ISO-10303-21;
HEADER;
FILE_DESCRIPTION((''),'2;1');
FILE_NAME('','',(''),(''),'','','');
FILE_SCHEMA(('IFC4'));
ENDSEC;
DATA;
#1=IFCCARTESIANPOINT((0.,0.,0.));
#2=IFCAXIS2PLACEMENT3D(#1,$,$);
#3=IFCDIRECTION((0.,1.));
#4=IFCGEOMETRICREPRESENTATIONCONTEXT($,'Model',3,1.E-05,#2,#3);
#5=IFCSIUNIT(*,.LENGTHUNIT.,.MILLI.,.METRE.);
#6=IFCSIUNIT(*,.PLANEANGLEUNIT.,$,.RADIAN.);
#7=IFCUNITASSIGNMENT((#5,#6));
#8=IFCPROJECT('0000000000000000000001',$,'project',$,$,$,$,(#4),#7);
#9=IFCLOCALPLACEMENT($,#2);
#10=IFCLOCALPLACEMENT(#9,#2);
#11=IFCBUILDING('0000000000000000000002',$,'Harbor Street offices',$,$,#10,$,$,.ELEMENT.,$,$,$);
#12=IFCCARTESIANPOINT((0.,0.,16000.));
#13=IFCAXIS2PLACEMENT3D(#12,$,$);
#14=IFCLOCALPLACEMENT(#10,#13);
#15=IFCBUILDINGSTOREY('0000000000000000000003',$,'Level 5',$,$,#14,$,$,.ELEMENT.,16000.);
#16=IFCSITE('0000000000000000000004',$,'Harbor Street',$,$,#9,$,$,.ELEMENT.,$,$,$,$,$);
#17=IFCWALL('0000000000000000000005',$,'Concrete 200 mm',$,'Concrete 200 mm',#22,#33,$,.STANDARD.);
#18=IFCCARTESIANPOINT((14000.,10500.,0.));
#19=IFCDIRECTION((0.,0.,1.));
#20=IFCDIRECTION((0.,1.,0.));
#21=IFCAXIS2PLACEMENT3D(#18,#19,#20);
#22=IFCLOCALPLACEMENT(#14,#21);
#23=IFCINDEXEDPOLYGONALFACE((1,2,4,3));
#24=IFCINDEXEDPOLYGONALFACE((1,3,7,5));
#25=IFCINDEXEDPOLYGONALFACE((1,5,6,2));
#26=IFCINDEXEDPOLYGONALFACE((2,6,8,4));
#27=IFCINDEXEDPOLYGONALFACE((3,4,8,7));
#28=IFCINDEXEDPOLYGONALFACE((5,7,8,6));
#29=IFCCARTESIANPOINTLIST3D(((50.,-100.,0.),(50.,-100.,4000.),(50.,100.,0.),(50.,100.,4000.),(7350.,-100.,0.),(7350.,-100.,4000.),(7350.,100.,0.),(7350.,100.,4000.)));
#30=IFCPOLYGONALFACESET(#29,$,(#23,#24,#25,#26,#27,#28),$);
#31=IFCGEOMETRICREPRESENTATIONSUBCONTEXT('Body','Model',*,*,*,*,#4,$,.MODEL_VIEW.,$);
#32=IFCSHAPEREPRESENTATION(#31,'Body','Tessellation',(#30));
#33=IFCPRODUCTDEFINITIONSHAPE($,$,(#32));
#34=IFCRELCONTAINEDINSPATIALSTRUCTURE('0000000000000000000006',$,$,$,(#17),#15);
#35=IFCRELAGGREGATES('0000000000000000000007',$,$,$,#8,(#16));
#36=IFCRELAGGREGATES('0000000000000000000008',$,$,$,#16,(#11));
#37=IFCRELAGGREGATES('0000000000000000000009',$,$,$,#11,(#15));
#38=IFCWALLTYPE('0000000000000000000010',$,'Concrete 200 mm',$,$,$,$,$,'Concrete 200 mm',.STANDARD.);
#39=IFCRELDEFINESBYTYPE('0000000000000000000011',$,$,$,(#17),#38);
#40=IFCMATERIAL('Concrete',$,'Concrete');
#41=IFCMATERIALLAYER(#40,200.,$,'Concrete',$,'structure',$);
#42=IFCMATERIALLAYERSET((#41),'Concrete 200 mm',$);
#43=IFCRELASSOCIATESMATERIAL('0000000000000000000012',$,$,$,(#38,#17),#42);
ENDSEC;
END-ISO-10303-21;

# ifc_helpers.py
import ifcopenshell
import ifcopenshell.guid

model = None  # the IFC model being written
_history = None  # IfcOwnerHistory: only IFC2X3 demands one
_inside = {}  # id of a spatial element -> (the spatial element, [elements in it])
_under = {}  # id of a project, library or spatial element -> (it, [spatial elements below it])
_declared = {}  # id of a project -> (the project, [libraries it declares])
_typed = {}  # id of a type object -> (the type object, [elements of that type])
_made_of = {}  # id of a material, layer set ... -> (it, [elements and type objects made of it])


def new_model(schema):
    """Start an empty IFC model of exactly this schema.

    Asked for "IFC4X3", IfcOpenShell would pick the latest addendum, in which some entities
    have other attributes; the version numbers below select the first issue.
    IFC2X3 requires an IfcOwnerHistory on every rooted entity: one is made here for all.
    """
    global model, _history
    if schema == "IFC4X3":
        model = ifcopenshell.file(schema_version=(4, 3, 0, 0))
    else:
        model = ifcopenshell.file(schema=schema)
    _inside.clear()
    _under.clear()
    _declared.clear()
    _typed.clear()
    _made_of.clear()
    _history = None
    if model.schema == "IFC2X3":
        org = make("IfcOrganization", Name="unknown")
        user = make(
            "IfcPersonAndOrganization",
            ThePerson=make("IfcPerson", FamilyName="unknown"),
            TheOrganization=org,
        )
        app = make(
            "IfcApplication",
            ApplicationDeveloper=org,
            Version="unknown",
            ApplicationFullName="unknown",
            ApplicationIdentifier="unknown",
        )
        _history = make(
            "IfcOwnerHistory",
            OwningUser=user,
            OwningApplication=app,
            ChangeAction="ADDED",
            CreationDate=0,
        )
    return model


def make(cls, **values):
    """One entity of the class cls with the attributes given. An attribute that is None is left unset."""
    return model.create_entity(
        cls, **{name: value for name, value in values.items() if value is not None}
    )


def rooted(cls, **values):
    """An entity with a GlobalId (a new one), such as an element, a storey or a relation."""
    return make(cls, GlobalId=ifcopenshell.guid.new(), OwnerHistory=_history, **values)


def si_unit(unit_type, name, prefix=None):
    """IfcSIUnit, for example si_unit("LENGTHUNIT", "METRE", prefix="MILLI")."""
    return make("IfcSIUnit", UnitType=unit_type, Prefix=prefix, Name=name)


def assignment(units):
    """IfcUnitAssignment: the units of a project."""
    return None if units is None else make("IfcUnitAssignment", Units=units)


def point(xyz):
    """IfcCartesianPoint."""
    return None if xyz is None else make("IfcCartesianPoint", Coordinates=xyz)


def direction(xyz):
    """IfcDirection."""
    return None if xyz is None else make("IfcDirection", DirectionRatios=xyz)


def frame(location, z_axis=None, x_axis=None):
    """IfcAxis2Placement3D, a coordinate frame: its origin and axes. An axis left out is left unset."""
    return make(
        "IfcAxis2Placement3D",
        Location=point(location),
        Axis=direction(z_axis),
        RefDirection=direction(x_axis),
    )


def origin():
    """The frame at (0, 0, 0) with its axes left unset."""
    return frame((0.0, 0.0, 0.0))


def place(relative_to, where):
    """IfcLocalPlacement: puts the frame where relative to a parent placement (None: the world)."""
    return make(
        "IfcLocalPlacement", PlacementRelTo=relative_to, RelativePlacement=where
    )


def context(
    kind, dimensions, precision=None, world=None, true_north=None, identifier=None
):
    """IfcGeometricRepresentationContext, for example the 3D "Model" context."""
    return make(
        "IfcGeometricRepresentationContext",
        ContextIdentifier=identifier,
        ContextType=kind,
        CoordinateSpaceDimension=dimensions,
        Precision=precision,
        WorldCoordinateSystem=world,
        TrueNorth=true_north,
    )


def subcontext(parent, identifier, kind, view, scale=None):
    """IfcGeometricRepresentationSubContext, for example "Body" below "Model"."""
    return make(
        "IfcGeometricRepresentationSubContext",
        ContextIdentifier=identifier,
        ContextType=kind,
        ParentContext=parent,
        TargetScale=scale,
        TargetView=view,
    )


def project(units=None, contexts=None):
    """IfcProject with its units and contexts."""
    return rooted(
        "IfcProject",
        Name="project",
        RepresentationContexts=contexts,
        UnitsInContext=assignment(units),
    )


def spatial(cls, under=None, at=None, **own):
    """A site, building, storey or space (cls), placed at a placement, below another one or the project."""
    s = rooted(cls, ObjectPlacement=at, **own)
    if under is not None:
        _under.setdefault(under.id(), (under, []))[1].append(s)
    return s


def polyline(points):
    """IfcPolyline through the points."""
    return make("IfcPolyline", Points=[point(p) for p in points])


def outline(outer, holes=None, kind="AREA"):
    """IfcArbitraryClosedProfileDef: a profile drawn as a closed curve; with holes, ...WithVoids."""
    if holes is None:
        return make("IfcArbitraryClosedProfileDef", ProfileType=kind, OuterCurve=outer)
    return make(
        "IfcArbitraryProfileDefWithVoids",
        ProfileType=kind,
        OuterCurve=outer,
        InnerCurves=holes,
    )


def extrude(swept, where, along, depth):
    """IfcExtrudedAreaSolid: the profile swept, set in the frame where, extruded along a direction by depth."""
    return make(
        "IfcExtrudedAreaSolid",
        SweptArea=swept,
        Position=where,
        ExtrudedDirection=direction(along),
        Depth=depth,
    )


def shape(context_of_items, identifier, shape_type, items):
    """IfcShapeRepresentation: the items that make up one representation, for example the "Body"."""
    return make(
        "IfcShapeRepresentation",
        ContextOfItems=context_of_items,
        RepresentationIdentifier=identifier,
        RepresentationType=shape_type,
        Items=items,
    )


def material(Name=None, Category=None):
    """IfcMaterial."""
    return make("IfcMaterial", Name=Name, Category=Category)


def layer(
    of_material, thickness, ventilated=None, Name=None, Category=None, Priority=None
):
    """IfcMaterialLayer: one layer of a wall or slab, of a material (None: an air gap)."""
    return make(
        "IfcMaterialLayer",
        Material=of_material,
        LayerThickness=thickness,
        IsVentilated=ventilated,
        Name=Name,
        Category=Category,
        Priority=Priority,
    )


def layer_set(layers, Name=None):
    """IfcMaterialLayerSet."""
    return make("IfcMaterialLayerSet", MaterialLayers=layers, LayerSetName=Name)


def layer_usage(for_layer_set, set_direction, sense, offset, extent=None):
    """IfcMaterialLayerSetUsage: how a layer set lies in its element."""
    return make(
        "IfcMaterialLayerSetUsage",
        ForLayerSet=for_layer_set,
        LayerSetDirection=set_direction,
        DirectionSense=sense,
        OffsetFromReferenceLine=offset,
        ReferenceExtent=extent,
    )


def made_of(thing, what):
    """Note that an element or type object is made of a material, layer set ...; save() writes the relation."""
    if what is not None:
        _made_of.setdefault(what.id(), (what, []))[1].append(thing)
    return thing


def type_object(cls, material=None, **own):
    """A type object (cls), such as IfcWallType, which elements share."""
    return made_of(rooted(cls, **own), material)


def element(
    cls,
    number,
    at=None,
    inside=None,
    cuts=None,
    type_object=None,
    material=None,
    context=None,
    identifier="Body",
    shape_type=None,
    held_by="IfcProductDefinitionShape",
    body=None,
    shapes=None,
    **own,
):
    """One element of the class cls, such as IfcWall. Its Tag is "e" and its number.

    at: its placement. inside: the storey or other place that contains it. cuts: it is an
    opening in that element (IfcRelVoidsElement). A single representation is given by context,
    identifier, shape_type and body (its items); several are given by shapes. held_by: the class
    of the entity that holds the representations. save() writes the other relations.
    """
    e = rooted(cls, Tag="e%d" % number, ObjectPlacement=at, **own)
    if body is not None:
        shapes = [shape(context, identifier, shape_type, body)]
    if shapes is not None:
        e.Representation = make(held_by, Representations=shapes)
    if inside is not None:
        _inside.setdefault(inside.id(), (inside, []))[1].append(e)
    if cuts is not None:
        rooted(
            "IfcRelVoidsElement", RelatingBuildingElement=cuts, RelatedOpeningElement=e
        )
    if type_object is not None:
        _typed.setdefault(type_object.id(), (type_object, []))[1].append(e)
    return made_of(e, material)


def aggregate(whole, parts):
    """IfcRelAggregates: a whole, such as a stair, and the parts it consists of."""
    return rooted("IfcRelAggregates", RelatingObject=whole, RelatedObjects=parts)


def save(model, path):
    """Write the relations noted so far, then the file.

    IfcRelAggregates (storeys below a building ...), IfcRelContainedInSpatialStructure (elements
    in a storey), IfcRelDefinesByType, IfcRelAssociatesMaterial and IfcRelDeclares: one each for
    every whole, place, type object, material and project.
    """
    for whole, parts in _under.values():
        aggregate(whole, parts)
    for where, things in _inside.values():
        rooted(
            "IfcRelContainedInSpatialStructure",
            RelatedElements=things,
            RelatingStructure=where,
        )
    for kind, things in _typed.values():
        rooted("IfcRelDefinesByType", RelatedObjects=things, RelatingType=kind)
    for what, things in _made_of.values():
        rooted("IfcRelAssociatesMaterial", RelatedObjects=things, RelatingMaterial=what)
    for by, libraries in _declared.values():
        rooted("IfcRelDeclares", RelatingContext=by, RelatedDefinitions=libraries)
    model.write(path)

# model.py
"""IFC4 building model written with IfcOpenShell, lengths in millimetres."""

from ifc_helpers import new_model, si_unit, direction, frame, origin, place, context, subcontext, project, spatial, polyline, outline, extrude, material, layer, layer_set, layer_usage, type_object, element, save


model = new_model("IFC4")

# Units and contexts
model_context = context("Model", 3, precision=1e-05, world=origin(), true_north=direction((0.0, 1.0)))
body_context = subcontext(model_context, "Body", "Model", "MODEL_VIEW")
ifc_project = project(units=[si_unit("LENGTHUNIT", "METRE", prefix="MILLI"), si_unit("PLANEANGLEUNIT", "RADIAN")], contexts=[model_context])

# Site, building, storey
site_placement = place(None, origin())
site = spatial("IfcSite", under=ifc_project, at=site_placement, Name="Harbor Street", CompositionType="ELEMENT")
building_placement = place(site_placement, origin())
building = spatial("IfcBuilding", under=site, at=building_placement, Name="Harbor Street offices", CompositionType="ELEMENT")
storey_placement = place(building_placement, frame((0.0, 0.0, 16000.0)))
storey = spatial("IfcBuildingStorey", under=building, at=storey_placement, Name="Level 5", CompositionType="ELEMENT", Elevation=16000.0)

# Shared definitions
ifc_material_1 = material(Name="Concrete", Category="Concrete")

# Wall
ifc_layer_1 = layer(ifc_material_1, 200.0, Name="Concrete", Category="structure")
ifc_layer_set_1 = layer_set([ifc_layer_1], Name="Concrete 200 mm")
ifc_layer_usage_1 = layer_usage(ifc_layer_set_1, "AXIS2", "NEGATIVE", 100.0)
wall_type_1 = type_object("IfcWallType", Name="Concrete 200 mm", ElementType="Concrete 200 mm", PredefinedType="STANDARD", material=ifc_layer_set_1)
wall_1_placement = place(storey_placement, frame((14000.0, 10500.0, 0.0), z_axis=(0.0, 0.0, 1.0), x_axis=(0.0, 1.0, 0.0)))
element("IfcWall", 1, at=wall_1_placement, inside=storey, type_object=wall_type_1, material=ifc_layer_usage_1, Name="Concrete 200 mm", ObjectType="Concrete 200 mm", PredefinedType="STANDARD", context=body_context, shape_type="SweptSolid", body=[
    extrude(outline(polyline([(50.0, -100.0), (7350.0, -100.0), (7350.0, 100.0), (50.0, 100.0), (50.0, -100.0)])), origin(), (0.0, 0.0, 1.0), 4000.0),
])

save(model, "model.ifc")
